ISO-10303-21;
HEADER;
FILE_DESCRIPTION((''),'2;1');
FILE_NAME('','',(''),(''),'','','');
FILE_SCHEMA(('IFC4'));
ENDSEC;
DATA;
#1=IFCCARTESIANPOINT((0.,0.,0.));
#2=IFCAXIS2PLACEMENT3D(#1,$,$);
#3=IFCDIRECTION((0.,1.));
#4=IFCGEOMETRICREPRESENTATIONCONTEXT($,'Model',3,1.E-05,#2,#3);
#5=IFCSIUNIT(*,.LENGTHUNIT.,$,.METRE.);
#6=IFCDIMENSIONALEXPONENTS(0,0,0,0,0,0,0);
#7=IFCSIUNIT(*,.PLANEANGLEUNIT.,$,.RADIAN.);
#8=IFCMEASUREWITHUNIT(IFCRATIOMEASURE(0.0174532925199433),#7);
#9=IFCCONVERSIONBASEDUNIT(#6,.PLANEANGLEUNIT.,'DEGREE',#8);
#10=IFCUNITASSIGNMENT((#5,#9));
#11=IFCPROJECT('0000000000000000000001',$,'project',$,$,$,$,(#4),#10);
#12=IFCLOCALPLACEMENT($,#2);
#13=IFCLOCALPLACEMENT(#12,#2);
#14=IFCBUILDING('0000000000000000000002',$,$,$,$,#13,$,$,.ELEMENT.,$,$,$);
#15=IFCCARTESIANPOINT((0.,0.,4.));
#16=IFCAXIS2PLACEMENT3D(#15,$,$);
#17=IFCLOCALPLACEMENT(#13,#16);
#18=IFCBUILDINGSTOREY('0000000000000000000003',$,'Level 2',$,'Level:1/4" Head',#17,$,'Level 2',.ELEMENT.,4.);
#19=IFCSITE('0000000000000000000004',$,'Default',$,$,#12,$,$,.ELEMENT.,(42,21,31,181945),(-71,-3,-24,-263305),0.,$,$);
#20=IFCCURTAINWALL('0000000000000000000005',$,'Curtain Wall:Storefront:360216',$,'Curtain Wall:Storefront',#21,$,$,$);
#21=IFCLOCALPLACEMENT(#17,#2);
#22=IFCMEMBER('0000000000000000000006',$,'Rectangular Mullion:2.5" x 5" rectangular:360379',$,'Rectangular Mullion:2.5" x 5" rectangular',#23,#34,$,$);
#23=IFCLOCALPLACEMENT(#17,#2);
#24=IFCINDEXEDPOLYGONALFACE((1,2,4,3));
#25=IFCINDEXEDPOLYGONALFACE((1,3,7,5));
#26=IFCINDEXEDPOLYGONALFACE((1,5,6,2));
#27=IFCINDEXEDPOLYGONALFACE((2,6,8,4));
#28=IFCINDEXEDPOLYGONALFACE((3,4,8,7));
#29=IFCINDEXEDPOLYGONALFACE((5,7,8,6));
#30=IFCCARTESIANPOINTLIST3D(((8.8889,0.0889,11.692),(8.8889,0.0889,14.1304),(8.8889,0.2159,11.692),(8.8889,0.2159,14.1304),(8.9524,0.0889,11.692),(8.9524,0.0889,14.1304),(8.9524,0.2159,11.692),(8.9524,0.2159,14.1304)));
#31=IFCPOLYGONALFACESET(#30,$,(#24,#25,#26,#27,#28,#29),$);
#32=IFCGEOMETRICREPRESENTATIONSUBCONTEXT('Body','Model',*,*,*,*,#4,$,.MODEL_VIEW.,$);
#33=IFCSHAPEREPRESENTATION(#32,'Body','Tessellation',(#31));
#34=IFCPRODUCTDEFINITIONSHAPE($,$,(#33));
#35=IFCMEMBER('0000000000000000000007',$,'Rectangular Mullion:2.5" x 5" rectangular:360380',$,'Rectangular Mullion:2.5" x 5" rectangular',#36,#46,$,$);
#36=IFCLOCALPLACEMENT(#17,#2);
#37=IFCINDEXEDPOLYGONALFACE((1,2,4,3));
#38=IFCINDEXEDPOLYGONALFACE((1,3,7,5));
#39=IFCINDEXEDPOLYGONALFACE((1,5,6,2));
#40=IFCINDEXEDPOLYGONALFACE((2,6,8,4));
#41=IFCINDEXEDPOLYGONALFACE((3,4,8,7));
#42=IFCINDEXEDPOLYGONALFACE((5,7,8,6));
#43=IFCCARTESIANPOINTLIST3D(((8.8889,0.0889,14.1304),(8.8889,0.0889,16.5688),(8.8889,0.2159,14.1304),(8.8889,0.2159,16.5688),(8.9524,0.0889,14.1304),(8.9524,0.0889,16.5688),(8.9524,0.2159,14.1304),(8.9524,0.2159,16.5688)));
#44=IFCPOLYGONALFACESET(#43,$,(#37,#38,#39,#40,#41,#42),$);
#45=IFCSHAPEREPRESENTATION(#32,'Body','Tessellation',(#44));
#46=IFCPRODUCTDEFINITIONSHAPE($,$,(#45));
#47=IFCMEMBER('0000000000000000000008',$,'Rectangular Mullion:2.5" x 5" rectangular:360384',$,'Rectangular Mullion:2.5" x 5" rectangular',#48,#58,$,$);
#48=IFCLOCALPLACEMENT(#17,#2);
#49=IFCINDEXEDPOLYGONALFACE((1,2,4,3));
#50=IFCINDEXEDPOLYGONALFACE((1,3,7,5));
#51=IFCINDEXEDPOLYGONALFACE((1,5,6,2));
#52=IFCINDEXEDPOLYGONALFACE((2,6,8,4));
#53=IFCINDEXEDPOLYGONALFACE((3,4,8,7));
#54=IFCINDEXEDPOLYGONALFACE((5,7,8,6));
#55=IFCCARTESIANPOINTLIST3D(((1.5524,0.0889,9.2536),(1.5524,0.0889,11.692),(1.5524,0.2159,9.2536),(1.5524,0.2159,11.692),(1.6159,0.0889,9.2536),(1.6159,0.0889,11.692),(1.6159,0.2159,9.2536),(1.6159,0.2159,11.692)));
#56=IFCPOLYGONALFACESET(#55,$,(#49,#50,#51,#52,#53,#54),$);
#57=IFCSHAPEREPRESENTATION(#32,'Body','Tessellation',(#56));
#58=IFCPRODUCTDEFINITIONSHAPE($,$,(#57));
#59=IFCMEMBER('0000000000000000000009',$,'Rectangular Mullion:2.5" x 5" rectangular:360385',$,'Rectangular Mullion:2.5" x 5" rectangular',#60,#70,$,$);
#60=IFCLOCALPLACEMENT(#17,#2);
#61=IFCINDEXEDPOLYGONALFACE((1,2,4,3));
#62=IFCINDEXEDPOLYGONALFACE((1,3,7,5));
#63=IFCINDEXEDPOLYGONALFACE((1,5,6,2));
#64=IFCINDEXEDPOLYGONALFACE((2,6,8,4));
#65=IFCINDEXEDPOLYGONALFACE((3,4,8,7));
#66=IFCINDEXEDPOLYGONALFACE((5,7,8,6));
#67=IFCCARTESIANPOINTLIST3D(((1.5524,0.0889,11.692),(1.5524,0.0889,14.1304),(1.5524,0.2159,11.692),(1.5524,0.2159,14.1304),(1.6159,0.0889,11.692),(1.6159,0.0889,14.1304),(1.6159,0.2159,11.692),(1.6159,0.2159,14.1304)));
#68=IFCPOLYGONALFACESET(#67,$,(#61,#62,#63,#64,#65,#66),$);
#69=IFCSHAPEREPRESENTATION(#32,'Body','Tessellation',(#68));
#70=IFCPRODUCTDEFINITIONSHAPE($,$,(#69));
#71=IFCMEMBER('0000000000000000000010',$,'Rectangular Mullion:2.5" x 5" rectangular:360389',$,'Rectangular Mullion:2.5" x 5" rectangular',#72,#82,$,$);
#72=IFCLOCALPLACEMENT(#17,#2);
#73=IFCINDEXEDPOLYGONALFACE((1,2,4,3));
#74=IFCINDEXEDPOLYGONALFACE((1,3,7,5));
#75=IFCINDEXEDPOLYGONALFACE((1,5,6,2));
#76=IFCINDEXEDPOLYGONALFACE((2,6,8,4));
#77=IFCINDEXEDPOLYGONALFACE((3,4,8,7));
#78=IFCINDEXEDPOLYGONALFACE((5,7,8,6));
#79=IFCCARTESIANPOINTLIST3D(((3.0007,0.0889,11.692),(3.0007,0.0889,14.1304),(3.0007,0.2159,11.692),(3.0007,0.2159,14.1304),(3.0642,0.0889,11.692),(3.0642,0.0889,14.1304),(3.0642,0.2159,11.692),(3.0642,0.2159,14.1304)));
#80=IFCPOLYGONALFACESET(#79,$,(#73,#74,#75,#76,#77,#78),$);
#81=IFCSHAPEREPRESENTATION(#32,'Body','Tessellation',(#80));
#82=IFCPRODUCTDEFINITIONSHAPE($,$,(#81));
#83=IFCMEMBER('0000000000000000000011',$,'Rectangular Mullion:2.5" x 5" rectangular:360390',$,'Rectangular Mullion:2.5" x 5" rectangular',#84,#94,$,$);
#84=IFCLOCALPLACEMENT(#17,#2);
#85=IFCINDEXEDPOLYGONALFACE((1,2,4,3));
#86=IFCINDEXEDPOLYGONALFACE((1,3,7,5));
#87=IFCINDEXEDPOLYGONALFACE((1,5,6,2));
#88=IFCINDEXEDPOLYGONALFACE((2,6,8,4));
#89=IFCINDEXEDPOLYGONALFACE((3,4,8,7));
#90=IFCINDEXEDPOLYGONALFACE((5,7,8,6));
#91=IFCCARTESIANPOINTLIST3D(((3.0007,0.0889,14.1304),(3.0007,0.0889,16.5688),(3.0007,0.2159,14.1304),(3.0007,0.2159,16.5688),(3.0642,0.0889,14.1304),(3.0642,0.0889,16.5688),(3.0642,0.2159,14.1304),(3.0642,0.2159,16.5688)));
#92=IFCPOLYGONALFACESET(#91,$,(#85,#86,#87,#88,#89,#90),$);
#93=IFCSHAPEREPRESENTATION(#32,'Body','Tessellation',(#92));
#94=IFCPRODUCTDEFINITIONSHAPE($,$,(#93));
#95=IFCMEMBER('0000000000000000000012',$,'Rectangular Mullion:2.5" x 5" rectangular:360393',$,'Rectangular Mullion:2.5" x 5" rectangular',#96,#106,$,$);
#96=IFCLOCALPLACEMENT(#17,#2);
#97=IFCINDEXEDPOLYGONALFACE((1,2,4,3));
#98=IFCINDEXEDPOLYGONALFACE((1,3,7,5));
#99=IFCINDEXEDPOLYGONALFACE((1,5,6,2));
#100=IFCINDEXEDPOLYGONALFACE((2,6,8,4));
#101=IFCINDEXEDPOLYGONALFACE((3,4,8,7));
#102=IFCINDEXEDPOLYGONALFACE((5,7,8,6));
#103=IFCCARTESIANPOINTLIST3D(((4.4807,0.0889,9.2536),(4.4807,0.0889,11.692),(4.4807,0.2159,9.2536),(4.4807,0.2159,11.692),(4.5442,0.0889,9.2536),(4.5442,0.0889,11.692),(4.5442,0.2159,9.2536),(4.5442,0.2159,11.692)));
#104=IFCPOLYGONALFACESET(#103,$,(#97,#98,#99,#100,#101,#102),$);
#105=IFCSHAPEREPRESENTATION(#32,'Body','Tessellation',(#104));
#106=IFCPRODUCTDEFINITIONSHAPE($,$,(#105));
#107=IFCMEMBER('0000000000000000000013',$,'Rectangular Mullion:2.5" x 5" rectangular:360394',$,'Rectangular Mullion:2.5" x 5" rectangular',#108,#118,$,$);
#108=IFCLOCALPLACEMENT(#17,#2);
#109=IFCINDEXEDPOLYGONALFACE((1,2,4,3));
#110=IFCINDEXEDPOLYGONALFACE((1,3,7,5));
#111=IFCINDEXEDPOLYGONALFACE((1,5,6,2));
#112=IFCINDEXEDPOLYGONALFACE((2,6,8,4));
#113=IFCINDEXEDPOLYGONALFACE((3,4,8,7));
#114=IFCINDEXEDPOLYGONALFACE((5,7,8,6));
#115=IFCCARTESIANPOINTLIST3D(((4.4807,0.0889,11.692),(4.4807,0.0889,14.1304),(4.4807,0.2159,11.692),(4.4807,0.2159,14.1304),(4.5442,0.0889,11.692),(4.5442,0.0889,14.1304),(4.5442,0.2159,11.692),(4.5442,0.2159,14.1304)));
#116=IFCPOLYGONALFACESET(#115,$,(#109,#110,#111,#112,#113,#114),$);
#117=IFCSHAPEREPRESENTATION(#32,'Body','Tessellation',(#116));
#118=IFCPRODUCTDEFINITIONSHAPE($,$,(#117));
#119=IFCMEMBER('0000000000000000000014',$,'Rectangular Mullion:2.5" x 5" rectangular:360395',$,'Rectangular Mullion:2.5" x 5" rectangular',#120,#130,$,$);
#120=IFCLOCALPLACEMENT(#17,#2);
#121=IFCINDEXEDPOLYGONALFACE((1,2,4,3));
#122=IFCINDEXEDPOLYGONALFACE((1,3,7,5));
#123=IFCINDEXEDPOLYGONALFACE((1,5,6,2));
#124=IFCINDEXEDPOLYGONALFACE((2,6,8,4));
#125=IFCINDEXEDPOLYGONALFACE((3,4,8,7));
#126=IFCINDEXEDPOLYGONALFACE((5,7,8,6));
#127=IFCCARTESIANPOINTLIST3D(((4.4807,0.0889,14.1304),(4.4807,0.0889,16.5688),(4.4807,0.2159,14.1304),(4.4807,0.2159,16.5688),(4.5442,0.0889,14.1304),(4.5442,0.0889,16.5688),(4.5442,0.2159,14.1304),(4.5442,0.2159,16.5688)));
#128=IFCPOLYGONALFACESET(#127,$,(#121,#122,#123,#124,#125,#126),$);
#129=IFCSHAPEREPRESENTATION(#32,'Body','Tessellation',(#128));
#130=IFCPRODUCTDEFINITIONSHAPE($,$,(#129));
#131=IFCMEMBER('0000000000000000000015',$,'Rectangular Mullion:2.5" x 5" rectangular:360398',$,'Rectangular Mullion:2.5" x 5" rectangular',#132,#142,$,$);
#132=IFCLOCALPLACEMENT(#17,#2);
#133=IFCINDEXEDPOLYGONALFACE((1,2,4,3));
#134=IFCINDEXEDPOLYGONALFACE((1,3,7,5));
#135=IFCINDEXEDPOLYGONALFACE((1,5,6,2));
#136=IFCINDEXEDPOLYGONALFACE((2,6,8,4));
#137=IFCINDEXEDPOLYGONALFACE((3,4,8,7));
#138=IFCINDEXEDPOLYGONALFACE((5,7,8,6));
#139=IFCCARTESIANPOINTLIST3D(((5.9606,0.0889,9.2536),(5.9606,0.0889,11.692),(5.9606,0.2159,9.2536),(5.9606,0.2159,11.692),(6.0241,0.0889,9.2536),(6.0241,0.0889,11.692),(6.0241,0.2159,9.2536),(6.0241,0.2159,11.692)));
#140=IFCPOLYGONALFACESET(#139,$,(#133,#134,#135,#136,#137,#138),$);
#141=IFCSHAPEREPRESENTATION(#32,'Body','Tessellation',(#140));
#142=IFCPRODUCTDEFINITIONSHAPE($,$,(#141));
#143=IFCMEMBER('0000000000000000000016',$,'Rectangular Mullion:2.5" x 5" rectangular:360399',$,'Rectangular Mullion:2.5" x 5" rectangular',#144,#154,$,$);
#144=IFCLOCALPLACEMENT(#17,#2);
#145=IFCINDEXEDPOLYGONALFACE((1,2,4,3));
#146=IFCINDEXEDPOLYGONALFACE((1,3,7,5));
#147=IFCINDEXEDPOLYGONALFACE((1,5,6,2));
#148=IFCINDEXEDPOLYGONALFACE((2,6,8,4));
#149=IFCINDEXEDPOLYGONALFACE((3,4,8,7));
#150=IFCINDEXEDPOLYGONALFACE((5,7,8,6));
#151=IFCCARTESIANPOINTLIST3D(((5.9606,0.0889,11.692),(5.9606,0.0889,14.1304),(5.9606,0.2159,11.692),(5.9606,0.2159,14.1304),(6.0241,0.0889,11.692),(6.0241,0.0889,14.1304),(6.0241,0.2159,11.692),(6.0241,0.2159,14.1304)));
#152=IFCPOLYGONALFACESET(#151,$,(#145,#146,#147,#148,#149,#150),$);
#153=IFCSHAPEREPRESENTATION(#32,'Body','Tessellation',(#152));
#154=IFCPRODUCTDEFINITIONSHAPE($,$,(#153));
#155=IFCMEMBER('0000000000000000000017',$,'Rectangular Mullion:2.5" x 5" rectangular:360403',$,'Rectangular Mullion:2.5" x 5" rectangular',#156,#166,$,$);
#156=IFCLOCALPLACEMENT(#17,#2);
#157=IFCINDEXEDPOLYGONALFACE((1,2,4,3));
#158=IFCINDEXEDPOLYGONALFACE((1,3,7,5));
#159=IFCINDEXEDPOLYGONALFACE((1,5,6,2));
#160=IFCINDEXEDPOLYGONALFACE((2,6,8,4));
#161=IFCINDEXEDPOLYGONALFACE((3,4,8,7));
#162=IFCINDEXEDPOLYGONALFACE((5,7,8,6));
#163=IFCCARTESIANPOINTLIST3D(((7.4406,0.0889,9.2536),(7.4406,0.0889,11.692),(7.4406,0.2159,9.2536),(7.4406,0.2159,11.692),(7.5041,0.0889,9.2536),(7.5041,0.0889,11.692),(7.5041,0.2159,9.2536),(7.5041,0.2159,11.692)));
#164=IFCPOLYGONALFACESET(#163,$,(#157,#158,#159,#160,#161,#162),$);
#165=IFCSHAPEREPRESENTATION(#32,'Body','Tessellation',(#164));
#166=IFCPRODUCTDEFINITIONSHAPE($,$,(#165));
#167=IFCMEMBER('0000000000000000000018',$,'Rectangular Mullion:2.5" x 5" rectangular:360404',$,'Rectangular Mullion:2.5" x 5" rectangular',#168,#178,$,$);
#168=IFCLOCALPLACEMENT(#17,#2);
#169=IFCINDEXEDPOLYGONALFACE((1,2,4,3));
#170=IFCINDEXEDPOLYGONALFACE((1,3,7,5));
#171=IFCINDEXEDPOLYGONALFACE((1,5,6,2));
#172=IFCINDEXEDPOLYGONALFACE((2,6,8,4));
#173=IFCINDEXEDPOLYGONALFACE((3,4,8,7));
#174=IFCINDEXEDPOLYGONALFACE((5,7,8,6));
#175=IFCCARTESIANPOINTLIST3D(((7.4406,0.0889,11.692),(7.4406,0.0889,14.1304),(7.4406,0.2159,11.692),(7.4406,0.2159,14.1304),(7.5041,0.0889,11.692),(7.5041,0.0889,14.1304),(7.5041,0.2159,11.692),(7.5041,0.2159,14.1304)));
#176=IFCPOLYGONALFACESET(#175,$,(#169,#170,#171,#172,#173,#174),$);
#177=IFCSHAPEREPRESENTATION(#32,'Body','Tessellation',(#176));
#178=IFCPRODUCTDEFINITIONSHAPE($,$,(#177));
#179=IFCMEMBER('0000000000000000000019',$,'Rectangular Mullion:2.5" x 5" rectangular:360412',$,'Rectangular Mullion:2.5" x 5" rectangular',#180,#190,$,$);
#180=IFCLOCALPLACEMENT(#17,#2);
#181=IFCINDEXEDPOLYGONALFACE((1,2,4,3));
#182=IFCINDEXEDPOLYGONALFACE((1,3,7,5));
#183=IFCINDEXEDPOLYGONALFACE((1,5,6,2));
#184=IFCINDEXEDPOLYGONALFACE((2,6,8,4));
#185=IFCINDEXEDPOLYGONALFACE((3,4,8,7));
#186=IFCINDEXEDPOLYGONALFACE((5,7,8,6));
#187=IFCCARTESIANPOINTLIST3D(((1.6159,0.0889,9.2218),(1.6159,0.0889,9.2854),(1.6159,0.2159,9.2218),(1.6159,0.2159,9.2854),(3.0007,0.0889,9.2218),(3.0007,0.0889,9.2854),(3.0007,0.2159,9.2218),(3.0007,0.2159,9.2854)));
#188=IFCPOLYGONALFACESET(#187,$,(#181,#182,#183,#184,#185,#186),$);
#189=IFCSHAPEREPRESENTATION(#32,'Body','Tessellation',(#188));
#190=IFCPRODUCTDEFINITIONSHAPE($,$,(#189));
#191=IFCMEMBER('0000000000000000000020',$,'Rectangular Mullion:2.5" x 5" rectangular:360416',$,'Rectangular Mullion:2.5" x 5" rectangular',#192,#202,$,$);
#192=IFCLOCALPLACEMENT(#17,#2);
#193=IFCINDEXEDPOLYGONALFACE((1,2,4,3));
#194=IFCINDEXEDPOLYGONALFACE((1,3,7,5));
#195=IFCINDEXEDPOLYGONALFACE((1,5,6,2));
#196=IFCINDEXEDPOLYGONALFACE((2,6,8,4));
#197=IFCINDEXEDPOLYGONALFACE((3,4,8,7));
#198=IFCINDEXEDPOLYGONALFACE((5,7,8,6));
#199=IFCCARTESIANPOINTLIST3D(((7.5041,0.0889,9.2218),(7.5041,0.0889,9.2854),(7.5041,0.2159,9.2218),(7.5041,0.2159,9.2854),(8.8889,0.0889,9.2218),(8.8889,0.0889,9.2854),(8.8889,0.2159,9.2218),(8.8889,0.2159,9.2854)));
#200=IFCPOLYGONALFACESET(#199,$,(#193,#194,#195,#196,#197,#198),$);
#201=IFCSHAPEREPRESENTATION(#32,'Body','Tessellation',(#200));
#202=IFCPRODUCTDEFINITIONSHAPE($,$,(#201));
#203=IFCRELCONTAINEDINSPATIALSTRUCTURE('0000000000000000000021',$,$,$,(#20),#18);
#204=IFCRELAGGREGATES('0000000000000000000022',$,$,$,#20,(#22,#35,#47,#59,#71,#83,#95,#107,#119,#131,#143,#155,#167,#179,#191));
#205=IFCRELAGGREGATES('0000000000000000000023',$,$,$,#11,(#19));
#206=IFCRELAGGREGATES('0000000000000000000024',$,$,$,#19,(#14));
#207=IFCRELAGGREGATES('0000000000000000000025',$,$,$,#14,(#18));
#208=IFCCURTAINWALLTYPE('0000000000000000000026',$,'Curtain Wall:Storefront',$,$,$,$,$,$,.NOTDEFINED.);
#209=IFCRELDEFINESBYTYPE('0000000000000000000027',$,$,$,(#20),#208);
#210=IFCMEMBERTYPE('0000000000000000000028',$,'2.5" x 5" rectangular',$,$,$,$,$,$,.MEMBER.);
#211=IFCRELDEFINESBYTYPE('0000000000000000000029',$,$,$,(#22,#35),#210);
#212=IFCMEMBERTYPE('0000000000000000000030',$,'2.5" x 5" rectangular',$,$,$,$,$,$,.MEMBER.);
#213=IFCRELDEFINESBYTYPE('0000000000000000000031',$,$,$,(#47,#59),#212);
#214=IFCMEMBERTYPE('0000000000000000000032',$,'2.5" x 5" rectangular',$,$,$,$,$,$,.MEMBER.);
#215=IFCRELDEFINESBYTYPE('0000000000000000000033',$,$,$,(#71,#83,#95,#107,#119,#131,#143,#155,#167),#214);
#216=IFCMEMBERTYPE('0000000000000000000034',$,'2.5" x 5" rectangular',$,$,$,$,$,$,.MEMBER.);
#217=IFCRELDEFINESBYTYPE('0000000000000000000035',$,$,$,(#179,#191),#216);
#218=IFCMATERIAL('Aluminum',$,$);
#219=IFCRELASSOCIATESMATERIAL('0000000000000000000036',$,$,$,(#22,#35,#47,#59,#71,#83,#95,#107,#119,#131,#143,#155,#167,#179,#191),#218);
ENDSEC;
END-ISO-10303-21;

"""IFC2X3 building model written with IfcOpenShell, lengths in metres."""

from ifc_helpers import new_model, entity, si_unit, converted_unit, direction, frame, origin, origin_2d_with_axis, place, context, subcontext, project, spatial, rectangle, extrude, source, transform, mapped, material, type_object, type_shapes, element, aggregate, save


model = new_model("IFC2X3")

# Units and contexts
model_context = context("Model", 3, precision=1e-05, world=origin(), true_north=direction((0.0, 1.0)))
body_context = subcontext(model_context, "Body", "Model", "MODEL_VIEW")
ifc_project = project(units=[si_unit("LENGTHUNIT", "METRE"), converted_unit("PLANEANGLEUNIT", "DEGREE", entity("IfcRatioMeasure", 0.0174532925199433), si_unit("PLANEANGLEUNIT", "RADIAN"), dimensions=[0, 0, 0, 0, 0, 0, 0])], contexts=[model_context])

# Site, building, storey
site_placement = place(None, origin())
site = spatial("IfcSite", under=ifc_project, at=site_placement, Name="Default", CompositionType="ELEMENT", RefLatitude=(42, 21, 31, 181945), RefLongitude=(-71, -3, -24, -263305), RefElevation=0.0)
building_placement = place(site_placement, origin())
building = spatial("IfcBuilding", under=site, at=building_placement, CompositionType="ELEMENT")
storey_placement = place(building_placement, frame((0.0, 0.0, 4.0)))
storey = spatial("IfcBuildingStorey", under=building, at=storey_placement, Name="Level 2", ObjectType="Level:1/4\" Head", LongName="Level 2", CompositionType="ELEMENT", Elevation=4.0)

# Curtain wall, members
curtain_wall_type = type_object("IfcCurtainWallType", Name="Curtain Wall:Storefront", PredefinedType="NOTDEFINED")
curtain_wall_placement = place(storey_placement, frame((0.0, 0.0, -4.0)))
curtain_wall = element("IfcCurtainWall", 1, at=curtain_wall_placement, inside=storey, type_object=curtain_wall_type, Name="Curtain Wall:Storefront:360216", ObjectType="Curtain Wall:Storefront")
ifc_material_1 = material(Name="Aluminum")
member_type_1 = type_object("IfcMemberType", Name="2.5\" x 5\" rectangular", PredefinedType="MEMBER")
shared_shape_1 = source(origin(), body_context, "Body", "SweptSolid", [
    extrude(rectangle(XDim=0.127, YDim=0.0635, at=origin_2d_with_axis()), frame((-0.0318, 0.0, -2.4384), z_axis=(0.0, 0.0, 1.0), x_axis=(0.0, -1.0, 0.0)), (0.0, 0.0, 1.0), 2.4384),
])
type_shapes(member_type_1, [shared_shape_1])
member_1_placement = place(storey_placement, frame((8.9524, 0.1524, 11.692), z_axis=(0.0, 0.0, -1.0), x_axis=(1.0, 0.0, 0.0)))
member_1 = element("IfcMember", 2, at=member_1_placement, type_object=member_type_1, material=ifc_material_1, Name="Rectangular Mullion:2.5\" x 5\" rectangular:360379", ObjectType="Rectangular Mullion:2.5\" x 5\" rectangular", context=body_context, shape_type="MappedRepresentation", body=[
    mapped(shared_shape_1, transform((0.0, 0.0, 0.0), scale=1.0)),
])
member_2_placement = place(storey_placement, frame((8.9524, 0.1524, 14.1304), z_axis=(0.0, 0.0, -1.0), x_axis=(1.0, 0.0, 0.0)))
member_2 = element("IfcMember", 3, at=member_2_placement, type_object=member_type_1, material=ifc_material_1, Name="Rectangular Mullion:2.5\" x 5\" rectangular:360380", ObjectType="Rectangular Mullion:2.5\" x 5\" rectangular", context=body_context, shape_type="MappedRepresentation", body=[
    mapped(shared_shape_1, transform((0.0, 0.0, 0.0), scale=1.0)),
])
member_type_2 = type_object("IfcMemberType", Name="2.5\" x 5\" rectangular", PredefinedType="MEMBER")
shared_shape_2 = source(origin(), body_context, "Body", "SweptSolid", [
    extrude(rectangle(XDim=0.127, YDim=0.0635, at=origin_2d_with_axis()), frame((-0.0318, 0.0, -2.4384), z_axis=(0.0, 0.0, 1.0), x_axis=(0.0, -1.0, 0.0)), (0.0, 0.0, 1.0), 2.4384),
])
type_shapes(member_type_2, [shared_shape_2])
member_3_placement = place(storey_placement, frame((1.5524, 0.1524, 11.692), z_axis=(0.0, 0.0, 1.0), x_axis=(-1.0, 0.0, 0.0)))
member_3 = element("IfcMember", 4, at=member_3_placement, type_object=member_type_2, material=ifc_material_1, Name="Rectangular Mullion:2.5\" x 5\" rectangular:360384", ObjectType="Rectangular Mullion:2.5\" x 5\" rectangular", context=body_context, shape_type="MappedRepresentation", body=[
    mapped(shared_shape_2, transform((0.0, 0.0, 0.0), scale=1.0)),
])
member_4_placement = place(storey_placement, frame((1.5524, 0.1524, 14.1304), z_axis=(0.0, 0.0, 1.0), x_axis=(-1.0, 0.0, 0.0)))
member_4 = element("IfcMember", 5, at=member_4_placement, type_object=member_type_2, material=ifc_material_1, Name="Rectangular Mullion:2.5\" x 5\" rectangular:360385", ObjectType="Rectangular Mullion:2.5\" x 5\" rectangular", context=body_context, shape_type="MappedRepresentation", body=[
    mapped(shared_shape_2, transform((0.0, 0.0, 0.0), scale=1.0)),
])
member_type_3 = type_object("IfcMemberType", Name="2.5\" x 5\" rectangular", PredefinedType="MEMBER")
shared_shape_3 = source(origin(), body_context, "Body", "SweptSolid", [
    extrude(rectangle(XDim=0.127, YDim=0.0635, at=origin_2d_with_axis()), frame((0.0, 0.0, -2.4384), z_axis=(0.0, 0.0, 1.0), x_axis=(0.0, -1.0, 0.0)), (0.0, 0.0, 1.0), 2.4384),
])
type_shapes(member_type_3, [shared_shape_3])
member_5_placement = place(storey_placement, frame((3.0324, 0.1524, 11.692), z_axis=(0.0, 0.0, -1.0), x_axis=(1.0, 0.0, 0.0)))
member_5 = element("IfcMember", 6, at=member_5_placement, type_object=member_type_3, material=ifc_material_1, Name="Rectangular Mullion:2.5\" x 5\" rectangular:360389", ObjectType="Rectangular Mullion:2.5\" x 5\" rectangular", context=body_context, shape_type="MappedRepresentation", body=[
    mapped(shared_shape_3, transform((0.0, 0.0, 0.0), scale=1.0)),
])
member_6_placement = place(storey_placement, frame((3.0324, 0.1524, 14.1304), z_axis=(0.0, 0.0, -1.0), x_axis=(1.0, 0.0, 0.0)))
member_6 = element("IfcMember", 7, at=member_6_placement, type_object=member_type_3, material=ifc_material_1, Name="Rectangular Mullion:2.5\" x 5\" rectangular:360390", ObjectType="Rectangular Mullion:2.5\" x 5\" rectangular", context=body_context, shape_type="MappedRepresentation", body=[
    mapped(shared_shape_3, transform((0.0, 0.0, 0.0), scale=1.0)),
])
member_7_placement = place(storey_placement, frame((4.5124, 0.1524, 9.2536), z_axis=(0.0, 0.0, -1.0), x_axis=(1.0, 0.0, 0.0)))
member_7 = element("IfcMember", 8, at=member_7_placement, type_object=member_type_3, material=ifc_material_1, Name="Rectangular Mullion:2.5\" x 5\" rectangular:360393", ObjectType="Rectangular Mullion:2.5\" x 5\" rectangular", context=body_context, shape_type="MappedRepresentation", body=[
    mapped(shared_shape_3, transform((0.0, 0.0, 0.0), scale=1.0)),
])
member_8_placement = place(storey_placement, frame((4.5124, 0.1524, 11.692), z_axis=(0.0, 0.0, -1.0), x_axis=(1.0, 0.0, 0.0)))
member_8 = element("IfcMember", 9, at=member_8_placement, type_object=member_type_3, material=ifc_material_1, Name="Rectangular Mullion:2.5\" x 5\" rectangular:360394", ObjectType="Rectangular Mullion:2.5\" x 5\" rectangular", context=body_context, shape_type="MappedRepresentation", body=[
    mapped(shared_shape_3, transform((0.0, 0.0, 0.0), scale=1.0)),
])
member_9_placement = place(storey_placement, frame((4.5124, 0.1524, 14.1304), z_axis=(0.0, 0.0, -1.0), x_axis=(1.0, 0.0, 0.0)))
member_9 = element("IfcMember", 10, at=member_9_placement, type_object=member_type_3, material=ifc_material_1, Name="Rectangular Mullion:2.5\" x 5\" rectangular:360395", ObjectType="Rectangular Mullion:2.5\" x 5\" rectangular", context=body_context, shape_type="MappedRepresentation", body=[
    mapped(shared_shape_3, transform((0.0, 0.0, 0.0), scale=1.0)),
])
member_10_placement = place(storey_placement, frame((5.9924, 0.1524, 9.2536), z_axis=(0.0, 0.0, -1.0), x_axis=(1.0, 0.0, 0.0)))
member_10 = element("IfcMember", 11, at=member_10_placement, type_object=member_type_3, material=ifc_material_1, Name="Rectangular Mullion:2.5\" x 5\" rectangular:360398", ObjectType="Rectangular Mullion:2.5\" x 5\" rectangular", context=body_context, shape_type="MappedRepresentation", body=[
    mapped(shared_shape_3, transform((0.0, 0.0, 0.0), scale=1.0)),
])
member_11_placement = place(storey_placement, frame((5.9924, 0.1524, 11.692), z_axis=(0.0, 0.0, -1.0), x_axis=(1.0, 0.0, 0.0)))
member_11 = element("IfcMember", 12, at=member_11_placement, type_object=member_type_3, material=ifc_material_1, Name="Rectangular Mullion:2.5\" x 5\" rectangular:360399", ObjectType="Rectangular Mullion:2.5\" x 5\" rectangular", context=body_context, shape_type="MappedRepresentation", body=[
    mapped(shared_shape_3, transform((0.0, 0.0, 0.0), scale=1.0)),
])
member_12_placement = place(storey_placement, frame((7.4724, 0.1524, 9.2536), z_axis=(0.0, 0.0, -1.0), x_axis=(1.0, 0.0, 0.0)))
member_12 = element("IfcMember", 13, at=member_12_placement, type_object=member_type_3, material=ifc_material_1, Name="Rectangular Mullion:2.5\" x 5\" rectangular:360403", ObjectType="Rectangular Mullion:2.5\" x 5\" rectangular", context=body_context, shape_type="MappedRepresentation", body=[
    mapped(shared_shape_3, transform((0.0, 0.0, 0.0), scale=1.0)),
])
member_13_placement = place(storey_placement, frame((7.4724, 0.1524, 11.692), z_axis=(0.0, 0.0, -1.0), x_axis=(1.0, 0.0, 0.0)))
member_13 = element("IfcMember", 14, at=member_13_placement, type_object=member_type_3, material=ifc_material_1, Name="Rectangular Mullion:2.5\" x 5\" rectangular:360404", ObjectType="Rectangular Mullion:2.5\" x 5\" rectangular", context=body_context, shape_type="MappedRepresentation", body=[
    mapped(shared_shape_3, transform((0.0, 0.0, 0.0), scale=1.0)),
])
member_type_4 = type_object("IfcMemberType", Name="2.5\" x 5\" rectangular", PredefinedType="MEMBER")
shared_shape_4 = source(origin(), body_context, "Body", "SweptSolid", [
    extrude(rectangle(XDim=0.127, YDim=0.0635, at=origin_2d_with_axis()), frame((0.0, 0.0, -1.3848), z_axis=(0.0, 0.0, 1.0), x_axis=(0.0, -1.0, 0.0)), (0.0, 0.0, 1.0), 1.3848),
])
type_shapes(member_type_4, [shared_shape_4])
member_14_placement = place(storey_placement, frame((3.0007, 0.1524, 9.2536), z_axis=(1.0, 0.0, 0.0), x_axis=(0.0, 0.0, 1.0)))
member_14 = element("IfcMember", 15, at=member_14_placement, type_object=member_type_4, material=ifc_material_1, Name="Rectangular Mullion:2.5\" x 5\" rectangular:360412", ObjectType="Rectangular Mullion:2.5\" x 5\" rectangular", context=body_context, shape_type="MappedRepresentation", body=[
    mapped(shared_shape_4, transform((0.0, 0.0, 0.0), scale=1.0)),
])
member_15_placement = place(storey_placement, frame((8.8889, 0.1524, 9.2536), z_axis=(1.0, 0.0, 0.0), x_axis=(0.0, 0.0, 1.0)))
member_15 = element("IfcMember", 16, at=member_15_placement, type_object=member_type_4, material=ifc_material_1, Name="Rectangular Mullion:2.5\" x 5\" rectangular:360416", ObjectType="Rectangular Mullion:2.5\" x 5\" rectangular", context=body_context, shape_type="MappedRepresentation", body=[
    mapped(shared_shape_4, transform((0.0, 0.0, 0.0), scale=1.0)),
])
aggregate(curtain_wall, [member_1, member_2, member_3, member_4, member_5, member_6, member_7, member_8, member_9, member_10, member_11, member_12, member_13, member_14, member_15])

save(model, "model.ifc")
